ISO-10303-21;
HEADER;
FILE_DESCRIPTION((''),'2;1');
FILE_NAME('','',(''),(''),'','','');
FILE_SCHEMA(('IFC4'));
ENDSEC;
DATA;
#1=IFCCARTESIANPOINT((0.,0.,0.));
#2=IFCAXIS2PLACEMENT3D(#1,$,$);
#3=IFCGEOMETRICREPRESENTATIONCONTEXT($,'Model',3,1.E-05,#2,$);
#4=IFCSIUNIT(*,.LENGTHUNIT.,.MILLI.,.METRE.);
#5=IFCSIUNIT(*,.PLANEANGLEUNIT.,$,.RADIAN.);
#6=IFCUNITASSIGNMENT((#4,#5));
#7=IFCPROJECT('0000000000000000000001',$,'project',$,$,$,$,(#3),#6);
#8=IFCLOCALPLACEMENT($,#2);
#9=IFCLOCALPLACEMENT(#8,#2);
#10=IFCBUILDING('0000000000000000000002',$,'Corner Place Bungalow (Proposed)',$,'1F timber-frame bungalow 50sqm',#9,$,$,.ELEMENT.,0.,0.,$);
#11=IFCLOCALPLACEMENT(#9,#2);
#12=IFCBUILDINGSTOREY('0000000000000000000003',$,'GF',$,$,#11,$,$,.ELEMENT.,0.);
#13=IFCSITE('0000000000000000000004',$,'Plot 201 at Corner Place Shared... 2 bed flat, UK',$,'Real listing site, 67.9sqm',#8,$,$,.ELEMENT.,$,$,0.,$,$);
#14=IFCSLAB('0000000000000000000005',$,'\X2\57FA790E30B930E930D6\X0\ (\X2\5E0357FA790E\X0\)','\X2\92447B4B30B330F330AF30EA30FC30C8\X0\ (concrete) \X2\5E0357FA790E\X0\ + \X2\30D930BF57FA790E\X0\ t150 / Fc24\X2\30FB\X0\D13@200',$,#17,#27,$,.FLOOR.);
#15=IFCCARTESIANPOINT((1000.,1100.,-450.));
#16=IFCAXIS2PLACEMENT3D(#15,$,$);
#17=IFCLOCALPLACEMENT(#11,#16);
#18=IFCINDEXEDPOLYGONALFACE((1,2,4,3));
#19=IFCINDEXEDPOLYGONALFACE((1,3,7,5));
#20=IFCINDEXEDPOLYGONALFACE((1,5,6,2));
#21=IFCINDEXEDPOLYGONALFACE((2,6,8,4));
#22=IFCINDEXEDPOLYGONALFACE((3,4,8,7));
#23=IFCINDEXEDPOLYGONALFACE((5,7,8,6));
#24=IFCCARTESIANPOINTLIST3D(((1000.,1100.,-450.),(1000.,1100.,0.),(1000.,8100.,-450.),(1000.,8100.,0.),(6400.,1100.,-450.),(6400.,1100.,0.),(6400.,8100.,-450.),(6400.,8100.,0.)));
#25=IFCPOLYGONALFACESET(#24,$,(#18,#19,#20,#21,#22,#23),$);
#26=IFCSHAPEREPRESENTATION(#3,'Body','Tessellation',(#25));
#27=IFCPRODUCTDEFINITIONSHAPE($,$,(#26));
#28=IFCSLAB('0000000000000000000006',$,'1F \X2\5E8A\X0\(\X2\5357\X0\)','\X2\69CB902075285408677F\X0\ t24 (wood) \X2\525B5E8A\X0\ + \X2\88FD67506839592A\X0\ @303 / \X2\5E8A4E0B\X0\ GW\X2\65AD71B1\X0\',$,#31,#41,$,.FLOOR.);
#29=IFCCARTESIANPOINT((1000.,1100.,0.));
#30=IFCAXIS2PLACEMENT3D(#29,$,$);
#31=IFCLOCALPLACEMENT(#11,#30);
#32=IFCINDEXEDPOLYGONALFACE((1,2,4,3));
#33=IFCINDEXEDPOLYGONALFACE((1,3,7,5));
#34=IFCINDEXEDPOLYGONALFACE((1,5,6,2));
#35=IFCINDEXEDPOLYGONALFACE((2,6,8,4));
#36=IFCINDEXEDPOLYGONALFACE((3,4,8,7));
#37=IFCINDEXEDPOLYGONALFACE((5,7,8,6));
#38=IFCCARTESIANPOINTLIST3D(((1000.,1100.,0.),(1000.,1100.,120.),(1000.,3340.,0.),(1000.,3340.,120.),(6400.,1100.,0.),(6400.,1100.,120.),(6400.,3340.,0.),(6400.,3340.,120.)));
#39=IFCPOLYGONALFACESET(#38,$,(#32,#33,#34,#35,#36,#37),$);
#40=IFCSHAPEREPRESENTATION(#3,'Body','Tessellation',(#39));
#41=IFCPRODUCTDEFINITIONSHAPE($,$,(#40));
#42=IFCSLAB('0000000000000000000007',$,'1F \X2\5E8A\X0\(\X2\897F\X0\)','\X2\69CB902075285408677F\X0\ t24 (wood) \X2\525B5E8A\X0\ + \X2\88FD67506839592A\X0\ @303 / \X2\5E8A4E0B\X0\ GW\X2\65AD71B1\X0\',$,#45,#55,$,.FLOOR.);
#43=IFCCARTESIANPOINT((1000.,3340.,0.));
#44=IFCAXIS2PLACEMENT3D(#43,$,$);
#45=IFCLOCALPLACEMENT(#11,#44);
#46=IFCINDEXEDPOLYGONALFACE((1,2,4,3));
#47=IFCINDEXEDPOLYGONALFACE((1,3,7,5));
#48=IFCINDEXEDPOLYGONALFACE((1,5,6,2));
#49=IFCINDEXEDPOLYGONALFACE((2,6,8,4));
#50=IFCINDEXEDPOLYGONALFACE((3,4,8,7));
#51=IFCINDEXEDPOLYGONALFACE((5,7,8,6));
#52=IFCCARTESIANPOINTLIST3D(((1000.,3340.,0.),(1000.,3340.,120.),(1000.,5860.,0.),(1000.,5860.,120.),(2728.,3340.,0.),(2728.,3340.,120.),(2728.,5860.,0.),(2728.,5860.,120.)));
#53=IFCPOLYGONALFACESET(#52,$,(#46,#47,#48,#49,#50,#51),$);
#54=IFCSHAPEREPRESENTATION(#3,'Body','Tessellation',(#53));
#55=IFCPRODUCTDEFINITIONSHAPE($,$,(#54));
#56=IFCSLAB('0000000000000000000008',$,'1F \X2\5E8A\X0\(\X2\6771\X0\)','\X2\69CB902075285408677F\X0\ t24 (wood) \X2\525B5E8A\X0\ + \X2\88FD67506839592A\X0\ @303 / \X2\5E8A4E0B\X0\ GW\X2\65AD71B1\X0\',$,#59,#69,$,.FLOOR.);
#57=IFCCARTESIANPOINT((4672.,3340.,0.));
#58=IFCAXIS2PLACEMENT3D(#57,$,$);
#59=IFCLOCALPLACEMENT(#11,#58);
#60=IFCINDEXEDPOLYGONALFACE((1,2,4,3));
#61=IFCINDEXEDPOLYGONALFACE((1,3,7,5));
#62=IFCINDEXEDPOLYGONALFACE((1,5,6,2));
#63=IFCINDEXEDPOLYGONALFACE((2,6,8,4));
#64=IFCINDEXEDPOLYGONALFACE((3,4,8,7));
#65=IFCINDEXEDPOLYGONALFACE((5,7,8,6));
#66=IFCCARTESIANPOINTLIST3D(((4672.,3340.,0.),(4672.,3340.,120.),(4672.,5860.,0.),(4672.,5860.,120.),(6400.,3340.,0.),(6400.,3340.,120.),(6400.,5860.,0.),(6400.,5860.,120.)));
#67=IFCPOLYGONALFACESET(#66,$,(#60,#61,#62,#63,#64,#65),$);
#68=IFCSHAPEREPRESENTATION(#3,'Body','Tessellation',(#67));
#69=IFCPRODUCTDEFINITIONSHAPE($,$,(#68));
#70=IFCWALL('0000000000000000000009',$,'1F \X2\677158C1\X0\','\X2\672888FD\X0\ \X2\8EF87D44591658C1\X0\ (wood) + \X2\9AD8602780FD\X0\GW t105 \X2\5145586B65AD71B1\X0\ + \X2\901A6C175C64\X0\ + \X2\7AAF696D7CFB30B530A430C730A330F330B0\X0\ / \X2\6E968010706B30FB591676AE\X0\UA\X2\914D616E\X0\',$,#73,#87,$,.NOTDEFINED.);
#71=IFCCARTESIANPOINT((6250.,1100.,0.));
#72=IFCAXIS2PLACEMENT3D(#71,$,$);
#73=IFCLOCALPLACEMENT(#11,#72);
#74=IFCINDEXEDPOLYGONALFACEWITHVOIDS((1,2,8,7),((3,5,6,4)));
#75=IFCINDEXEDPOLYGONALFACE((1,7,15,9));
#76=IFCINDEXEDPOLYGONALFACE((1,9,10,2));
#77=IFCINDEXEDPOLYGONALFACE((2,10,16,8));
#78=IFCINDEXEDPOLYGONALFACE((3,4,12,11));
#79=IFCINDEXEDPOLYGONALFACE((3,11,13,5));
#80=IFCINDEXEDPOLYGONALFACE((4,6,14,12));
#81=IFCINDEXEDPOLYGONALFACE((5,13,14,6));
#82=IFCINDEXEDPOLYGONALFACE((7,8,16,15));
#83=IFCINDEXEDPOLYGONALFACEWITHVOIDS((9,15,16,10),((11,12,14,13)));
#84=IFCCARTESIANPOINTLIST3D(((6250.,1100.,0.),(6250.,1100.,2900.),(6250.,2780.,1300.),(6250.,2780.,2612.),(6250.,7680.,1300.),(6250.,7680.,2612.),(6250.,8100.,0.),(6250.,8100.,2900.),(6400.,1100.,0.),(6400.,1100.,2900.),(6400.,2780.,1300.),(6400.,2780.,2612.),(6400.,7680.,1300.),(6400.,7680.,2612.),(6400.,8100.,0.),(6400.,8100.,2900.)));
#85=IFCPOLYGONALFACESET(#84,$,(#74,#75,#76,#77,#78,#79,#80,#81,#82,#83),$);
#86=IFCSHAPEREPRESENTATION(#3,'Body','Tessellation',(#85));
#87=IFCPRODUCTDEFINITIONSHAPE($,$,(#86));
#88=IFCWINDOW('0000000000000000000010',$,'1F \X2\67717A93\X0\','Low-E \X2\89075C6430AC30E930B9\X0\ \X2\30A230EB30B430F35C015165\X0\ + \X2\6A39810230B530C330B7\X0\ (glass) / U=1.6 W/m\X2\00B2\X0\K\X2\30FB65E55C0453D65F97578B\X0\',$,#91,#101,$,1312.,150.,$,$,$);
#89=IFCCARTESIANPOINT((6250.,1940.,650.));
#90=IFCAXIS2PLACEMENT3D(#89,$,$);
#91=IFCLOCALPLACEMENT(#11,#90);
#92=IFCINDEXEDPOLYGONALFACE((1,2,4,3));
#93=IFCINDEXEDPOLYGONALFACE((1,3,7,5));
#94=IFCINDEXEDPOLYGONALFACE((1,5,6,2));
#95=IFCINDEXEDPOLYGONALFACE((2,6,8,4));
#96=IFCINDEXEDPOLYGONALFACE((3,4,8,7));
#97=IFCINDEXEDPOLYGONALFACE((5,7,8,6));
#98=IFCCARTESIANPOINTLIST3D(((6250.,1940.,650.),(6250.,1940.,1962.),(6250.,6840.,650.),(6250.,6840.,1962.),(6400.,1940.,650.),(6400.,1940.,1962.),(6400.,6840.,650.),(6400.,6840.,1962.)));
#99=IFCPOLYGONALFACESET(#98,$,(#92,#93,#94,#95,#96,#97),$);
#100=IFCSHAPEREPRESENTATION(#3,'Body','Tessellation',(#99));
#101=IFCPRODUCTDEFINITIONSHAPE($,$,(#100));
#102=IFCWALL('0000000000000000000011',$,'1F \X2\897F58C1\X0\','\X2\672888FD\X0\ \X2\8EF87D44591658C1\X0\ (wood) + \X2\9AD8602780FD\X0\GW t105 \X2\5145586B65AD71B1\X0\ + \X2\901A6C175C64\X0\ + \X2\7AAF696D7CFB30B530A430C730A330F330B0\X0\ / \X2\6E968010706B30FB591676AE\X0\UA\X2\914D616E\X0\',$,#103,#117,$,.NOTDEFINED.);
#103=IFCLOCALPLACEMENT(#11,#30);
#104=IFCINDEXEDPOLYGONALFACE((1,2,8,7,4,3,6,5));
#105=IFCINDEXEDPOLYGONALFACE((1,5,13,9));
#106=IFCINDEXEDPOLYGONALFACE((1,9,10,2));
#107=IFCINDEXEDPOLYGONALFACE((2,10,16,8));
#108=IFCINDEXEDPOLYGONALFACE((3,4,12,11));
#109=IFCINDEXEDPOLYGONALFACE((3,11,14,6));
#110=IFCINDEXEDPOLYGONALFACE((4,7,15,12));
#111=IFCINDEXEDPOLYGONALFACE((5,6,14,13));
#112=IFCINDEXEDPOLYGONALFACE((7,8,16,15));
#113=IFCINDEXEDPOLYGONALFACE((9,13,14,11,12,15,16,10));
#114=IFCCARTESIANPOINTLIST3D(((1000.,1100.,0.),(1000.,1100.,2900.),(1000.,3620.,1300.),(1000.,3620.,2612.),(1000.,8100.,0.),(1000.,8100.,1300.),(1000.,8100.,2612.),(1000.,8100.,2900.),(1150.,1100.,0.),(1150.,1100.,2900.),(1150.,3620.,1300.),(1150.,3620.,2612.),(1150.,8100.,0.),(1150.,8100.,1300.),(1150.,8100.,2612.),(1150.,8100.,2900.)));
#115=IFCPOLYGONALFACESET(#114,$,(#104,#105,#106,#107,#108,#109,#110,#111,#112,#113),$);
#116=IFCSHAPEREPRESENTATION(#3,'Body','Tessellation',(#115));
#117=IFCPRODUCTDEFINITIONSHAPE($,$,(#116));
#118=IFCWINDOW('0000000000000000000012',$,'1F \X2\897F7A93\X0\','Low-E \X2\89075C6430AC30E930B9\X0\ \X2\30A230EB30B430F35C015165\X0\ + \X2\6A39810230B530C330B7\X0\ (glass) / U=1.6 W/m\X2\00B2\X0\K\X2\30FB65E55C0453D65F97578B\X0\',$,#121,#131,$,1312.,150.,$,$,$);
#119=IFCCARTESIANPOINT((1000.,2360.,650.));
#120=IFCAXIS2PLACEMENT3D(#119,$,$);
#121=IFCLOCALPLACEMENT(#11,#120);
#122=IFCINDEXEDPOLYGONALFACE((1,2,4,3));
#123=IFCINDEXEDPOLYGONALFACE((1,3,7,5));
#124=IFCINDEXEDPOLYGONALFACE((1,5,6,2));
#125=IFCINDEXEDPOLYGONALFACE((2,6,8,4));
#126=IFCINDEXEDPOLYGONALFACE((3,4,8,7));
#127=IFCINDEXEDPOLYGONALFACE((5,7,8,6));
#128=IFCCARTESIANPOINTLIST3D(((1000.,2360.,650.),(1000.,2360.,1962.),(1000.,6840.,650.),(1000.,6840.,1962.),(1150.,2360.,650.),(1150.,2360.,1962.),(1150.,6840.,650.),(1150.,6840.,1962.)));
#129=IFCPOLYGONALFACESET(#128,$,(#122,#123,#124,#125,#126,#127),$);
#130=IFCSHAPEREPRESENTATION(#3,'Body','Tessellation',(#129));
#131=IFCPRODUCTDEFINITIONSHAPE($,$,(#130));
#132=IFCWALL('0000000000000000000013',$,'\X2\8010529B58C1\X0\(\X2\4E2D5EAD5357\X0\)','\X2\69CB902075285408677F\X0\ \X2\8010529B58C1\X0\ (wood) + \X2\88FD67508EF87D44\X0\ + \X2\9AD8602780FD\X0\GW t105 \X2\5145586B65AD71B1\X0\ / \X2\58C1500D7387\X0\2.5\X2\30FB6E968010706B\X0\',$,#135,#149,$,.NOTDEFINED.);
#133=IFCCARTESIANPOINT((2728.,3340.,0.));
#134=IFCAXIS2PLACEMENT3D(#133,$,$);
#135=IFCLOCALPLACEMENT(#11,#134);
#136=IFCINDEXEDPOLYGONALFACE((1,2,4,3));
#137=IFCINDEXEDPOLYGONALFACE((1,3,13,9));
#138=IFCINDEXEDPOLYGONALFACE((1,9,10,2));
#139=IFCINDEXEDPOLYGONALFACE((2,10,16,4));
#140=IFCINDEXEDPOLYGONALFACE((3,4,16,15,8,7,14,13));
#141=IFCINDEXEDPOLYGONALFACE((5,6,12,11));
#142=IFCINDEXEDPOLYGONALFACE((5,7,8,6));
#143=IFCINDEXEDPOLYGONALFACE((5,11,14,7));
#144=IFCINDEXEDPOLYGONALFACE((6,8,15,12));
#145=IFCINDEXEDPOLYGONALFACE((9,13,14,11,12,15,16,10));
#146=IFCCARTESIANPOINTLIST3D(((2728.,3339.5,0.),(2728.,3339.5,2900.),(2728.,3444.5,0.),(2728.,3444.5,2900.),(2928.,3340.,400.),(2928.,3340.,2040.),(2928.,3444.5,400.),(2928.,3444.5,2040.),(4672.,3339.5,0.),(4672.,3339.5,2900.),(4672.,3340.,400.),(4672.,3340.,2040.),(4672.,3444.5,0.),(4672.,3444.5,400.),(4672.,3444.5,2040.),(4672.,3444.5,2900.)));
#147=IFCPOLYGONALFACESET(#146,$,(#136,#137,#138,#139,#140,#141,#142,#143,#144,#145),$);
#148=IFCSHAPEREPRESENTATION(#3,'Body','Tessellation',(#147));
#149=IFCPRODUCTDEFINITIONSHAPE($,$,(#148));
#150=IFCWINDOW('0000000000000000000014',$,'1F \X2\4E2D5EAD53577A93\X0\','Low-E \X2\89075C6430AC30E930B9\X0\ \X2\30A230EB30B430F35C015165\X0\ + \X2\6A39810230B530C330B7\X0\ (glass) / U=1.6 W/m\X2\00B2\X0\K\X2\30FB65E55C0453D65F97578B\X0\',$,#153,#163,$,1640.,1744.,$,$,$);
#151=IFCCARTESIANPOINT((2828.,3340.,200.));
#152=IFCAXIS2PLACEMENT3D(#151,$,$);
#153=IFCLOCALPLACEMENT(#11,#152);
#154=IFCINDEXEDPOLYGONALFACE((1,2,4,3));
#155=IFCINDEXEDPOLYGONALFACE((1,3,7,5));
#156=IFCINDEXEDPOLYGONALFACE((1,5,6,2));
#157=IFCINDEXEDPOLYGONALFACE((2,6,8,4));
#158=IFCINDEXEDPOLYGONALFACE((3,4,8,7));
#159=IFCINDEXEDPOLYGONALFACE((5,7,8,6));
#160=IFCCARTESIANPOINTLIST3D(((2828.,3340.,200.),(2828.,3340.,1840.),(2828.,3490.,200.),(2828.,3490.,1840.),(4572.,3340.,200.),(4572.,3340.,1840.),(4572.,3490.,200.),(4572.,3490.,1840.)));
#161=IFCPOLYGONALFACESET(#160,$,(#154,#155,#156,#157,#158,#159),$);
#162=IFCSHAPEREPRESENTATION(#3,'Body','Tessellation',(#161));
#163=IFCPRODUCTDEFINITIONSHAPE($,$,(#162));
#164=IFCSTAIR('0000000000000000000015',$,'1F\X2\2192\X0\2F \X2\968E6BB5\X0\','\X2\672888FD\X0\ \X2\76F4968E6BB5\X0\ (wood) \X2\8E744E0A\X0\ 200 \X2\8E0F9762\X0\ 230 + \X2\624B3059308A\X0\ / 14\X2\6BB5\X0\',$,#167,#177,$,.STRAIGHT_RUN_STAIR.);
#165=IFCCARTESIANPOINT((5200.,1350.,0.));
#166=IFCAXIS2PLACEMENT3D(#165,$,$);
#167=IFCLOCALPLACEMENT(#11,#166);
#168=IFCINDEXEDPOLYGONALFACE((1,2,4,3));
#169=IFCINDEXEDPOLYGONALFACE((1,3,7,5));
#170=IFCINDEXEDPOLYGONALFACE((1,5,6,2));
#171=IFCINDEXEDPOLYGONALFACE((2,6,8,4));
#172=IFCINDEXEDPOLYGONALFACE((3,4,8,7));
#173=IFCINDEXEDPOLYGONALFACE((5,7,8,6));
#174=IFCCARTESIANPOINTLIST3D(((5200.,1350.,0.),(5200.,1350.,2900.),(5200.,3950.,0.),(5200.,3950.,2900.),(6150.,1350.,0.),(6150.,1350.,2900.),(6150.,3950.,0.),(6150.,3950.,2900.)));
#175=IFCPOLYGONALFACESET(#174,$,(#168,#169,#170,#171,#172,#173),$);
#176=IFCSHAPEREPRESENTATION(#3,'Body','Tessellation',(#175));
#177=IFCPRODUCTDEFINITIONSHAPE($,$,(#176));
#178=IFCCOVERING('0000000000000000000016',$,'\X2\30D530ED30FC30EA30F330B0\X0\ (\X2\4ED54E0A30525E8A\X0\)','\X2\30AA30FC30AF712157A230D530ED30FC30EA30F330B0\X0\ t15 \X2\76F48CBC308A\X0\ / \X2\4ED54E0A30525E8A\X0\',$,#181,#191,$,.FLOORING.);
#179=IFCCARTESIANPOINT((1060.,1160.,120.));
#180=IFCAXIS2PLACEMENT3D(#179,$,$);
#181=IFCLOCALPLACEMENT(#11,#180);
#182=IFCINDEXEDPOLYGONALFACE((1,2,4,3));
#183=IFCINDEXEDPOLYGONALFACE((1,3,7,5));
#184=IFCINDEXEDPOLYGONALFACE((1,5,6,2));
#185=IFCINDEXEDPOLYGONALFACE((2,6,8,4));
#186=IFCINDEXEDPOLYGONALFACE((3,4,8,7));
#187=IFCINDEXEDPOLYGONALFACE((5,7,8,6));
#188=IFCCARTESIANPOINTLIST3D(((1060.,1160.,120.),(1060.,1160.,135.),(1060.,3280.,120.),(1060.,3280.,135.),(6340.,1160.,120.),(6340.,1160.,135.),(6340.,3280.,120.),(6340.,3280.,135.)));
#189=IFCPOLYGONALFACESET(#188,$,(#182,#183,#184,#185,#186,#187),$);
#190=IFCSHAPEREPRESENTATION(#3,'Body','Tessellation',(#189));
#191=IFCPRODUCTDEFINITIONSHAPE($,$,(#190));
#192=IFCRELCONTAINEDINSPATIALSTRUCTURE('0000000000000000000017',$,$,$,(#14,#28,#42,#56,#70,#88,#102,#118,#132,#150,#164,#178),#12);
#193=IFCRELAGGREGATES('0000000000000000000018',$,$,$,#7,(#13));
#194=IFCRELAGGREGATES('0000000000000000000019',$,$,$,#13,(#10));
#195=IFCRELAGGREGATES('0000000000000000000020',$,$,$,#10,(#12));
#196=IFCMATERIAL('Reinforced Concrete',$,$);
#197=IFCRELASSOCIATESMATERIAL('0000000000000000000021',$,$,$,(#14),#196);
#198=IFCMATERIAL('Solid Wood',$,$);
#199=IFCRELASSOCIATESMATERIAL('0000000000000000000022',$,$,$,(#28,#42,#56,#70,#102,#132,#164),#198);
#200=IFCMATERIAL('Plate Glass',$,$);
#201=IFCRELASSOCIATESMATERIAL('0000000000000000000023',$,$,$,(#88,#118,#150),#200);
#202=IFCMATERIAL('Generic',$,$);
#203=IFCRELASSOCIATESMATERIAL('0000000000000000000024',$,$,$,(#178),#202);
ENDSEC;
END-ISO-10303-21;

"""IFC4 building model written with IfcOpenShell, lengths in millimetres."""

from ifc_helpers import new_model, si_unit, frame, frame_2d, origin, place, context, project, spatial, rectangle, extrude, material, element, fill, save


model = new_model("IFC4")

# Units and contexts
model_context = context("Model", 3, precision=1e-05, world=origin())
ifc_project = project(units=[si_unit("LENGTHUNIT", "METRE", prefix="MILLI"), si_unit("PLANEANGLEUNIT", "RADIAN")], contexts=[model_context])

# Site, building, storey
site_placement = place(None, origin())
site = spatial("IfcSite", under=ifc_project, at=site_placement, Name="Plot 201 at Corner Place Shared... 2 bed flat, UK", ObjectType="Real listing site, 67.9sqm", CompositionType="ELEMENT", RefElevation=0.0)
building_placement = place(site_placement, origin())
building = spatial("IfcBuilding", under=site, at=building_placement, Name="Corner Place Bungalow (Proposed)", ObjectType="1F timber-frame bungalow 50sqm", CompositionType="ELEMENT", ElevationOfRefHeight=0.0, ElevationOfTerrain=0.0)
storey_placement = place(building_placement, origin())
storey = spatial("IfcBuildingStorey", under=building, at=storey_placement, Name="GF", CompositionType="ELEMENT", Elevation=0.0)

# Slabs
ifc_material_1 = material(Name="Reinforced Concrete")
slab_1_placement = place(storey_placement, frame((1000.0, 1100.0, -450.0)))
element("IfcSlab", 1, at=slab_1_placement, inside=storey, material=ifc_material_1, Name="基礎スラブ (布基礎)", Description="鉄筋コンクリート (concrete) 布基礎 + ベタ基礎 t150 / Fc24・D13@200", PredefinedType="FLOOR", context=model_context, shape_type="SweptSolid", body=[
    extrude(rectangle(XDim=5400.0, YDim=7000.0, at=frame_2d((2700.0, 3500.0))), frame((1000.0, 1100.0, -450.0)), (0.0, 0.0, 1.0), 450.0),
])
ifc_material_2 = material(Name="Solid Wood")
slab_2_placement = place(storey_placement, frame((1000.0, 1100.0, 0.0)))
element("IfcSlab", 2, at=slab_2_placement, inside=storey, material=ifc_material_2, Name="1F 床(南)", Description="構造用合板 t24 (wood) 剛床 + 製材根太 @303 / 床下 GW断熱", PredefinedType="FLOOR", context=model_context, shape_type="SweptSolid", body=[
    extrude(rectangle(XDim=5400.0, YDim=2240.0, at=frame_2d((2700.0, 1120.0))), frame((1000.0, 1100.0, 0.0)), (0.0, 0.0, 1.0), 120.0),
])
slab_3_placement = place(storey_placement, frame((1000.0, 3340.0, 0.0)))
element("IfcSlab", 3, at=slab_3_placement, inside=storey, material=ifc_material_2, Name="1F 床(西)", Description="構造用合板 t24 (wood) 剛床 + 製材根太 @303 / 床下 GW断熱", PredefinedType="FLOOR", context=model_context, shape_type="SweptSolid", body=[
    extrude(rectangle(XDim=1728.0, YDim=2520.0, at=frame_2d((864.0, 1260.0))), frame((1000.0, 3340.0, 0.0)), (0.0, 0.0, 1.0), 120.0),
])
slab_4_placement = place(storey_placement, frame((4672.0, 3340.0, 0.0)))
element("IfcSlab", 4, at=slab_4_placement, inside=storey, material=ifc_material_2, Name="1F 床(東)", Description="構造用合板 t24 (wood) 剛床 + 製材根太 @303 / 床下 GW断熱", PredefinedType="FLOOR", context=model_context, shape_type="SweptSolid", body=[
    extrude(rectangle(XDim=1728.0, YDim=2520.0, at=frame_2d((864.0, 1260.0))), frame((4672.0, 3340.0, 0.0)), (0.0, 0.0, 1.0), 120.0),
])
ifc_material_3 = material(Name="Generic")

# Shared definitions
ifc_material_4 = material(Name="Plate Glass")

# Walls, openings, windows
wall_1_placement = place(storey_placement, frame((6250.0, 1100.0, 0.0)))
wall_1 = element("IfcWall", 5, at=wall_1_placement, inside=storey, material=ifc_material_2, Name="1F 東壁", Description="木製 軸組外壁 (wood) + 高性能GW t105 充填断熱 + 通気層 + 窯業系サイディング / 準耐火・外皮UA配慮", PredefinedType="NOTDEFINED", context=model_context, shape_type="SweptSolid", body=[
    extrude(rectangle(XDim=150.0, YDim=7000.0, at=frame_2d((75.0, 3500.0))), frame((6250.0, 1100.0, 0.0)), (0.0, 0.0, 1.0), 2900.0),
])
opening_1_placement = place(storey_placement, frame((6250.0, 1940.0, 650.0)))
opening_1 = element("IfcOpeningElement", 6, at=opening_1_placement, cuts=wall_1, PredefinedType="NOTDEFINED", context=model_context, shape_type="SweptSolid", body=[
    extrude(rectangle(XDim=150.0, YDim=4900.0, at=frame_2d((75.0, 2450.0))), frame((6250.0, 1940.0, 650.0)), (0.0, 0.0, 1.0), 1312.0),
])
window_1_placement = place(storey_placement, frame((6250.0, 1940.0, 650.0)))
window_1 = element("IfcWindow", 7, at=window_1_placement, inside=storey, material=ifc_material_4, Name="1F 東窓", Description="Low-E 複層ガラス アルゴン封入 + 樹脂サッシ (glass) / U=1.6 W/m²K・日射取得型", OverallHeight=1312.0, OverallWidth=150.0, context=model_context, shape_type="SweptSolid", body=[
    extrude(rectangle(XDim=150.0, YDim=4900.0, at=frame_2d((75.0, 2450.0))), frame((6250.0, 1940.0, 650.0)), (0.0, 0.0, 1.0), 1312.0),
])
fill(opening_1, window_1)
wall_2_placement = place(storey_placement, frame((1000.0, 1100.0, 0.0)))
wall_2 = element("IfcWall", 8, at=wall_2_placement, inside=storey, material=ifc_material_2, Name="1F 西壁", Description="木製 軸組外壁 (wood) + 高性能GW t105 充填断熱 + 通気層 + 窯業系サイディング / 準耐火・外皮UA配慮", PredefinedType="NOTDEFINED", context=model_context, shape_type="SweptSolid", body=[
    extrude(rectangle(XDim=150.0, YDim=7000.0, at=frame_2d((75.0, 3500.0))), frame((1000.0, 1100.0, 0.0)), (0.0, 0.0, 1.0), 2900.0),
])
opening_2_placement = place(storey_placement, frame((1000.0, 2360.0, 650.0)))
opening_2 = element("IfcOpeningElement", 9, at=opening_2_placement, cuts=wall_2, PredefinedType="NOTDEFINED", context=model_context, shape_type="SweptSolid", body=[
    extrude(rectangle(XDim=150.0, YDim=4480.0, at=frame_2d((75.0, 2240.0))), frame((1000.0, 2360.0, 650.0)), (0.0, 0.0, 1.0), 1312.0),
])
window_2_placement = place(storey_placement, frame((1000.0, 2360.0, 650.0)))
window_2 = element("IfcWindow", 10, at=window_2_placement, inside=storey, material=ifc_material_4, Name="1F 西窓", Description="Low-E 複層ガラス アルゴン封入 + 樹脂サッシ (glass) / U=1.6 W/m²K・日射取得型", OverallHeight=1312.0, OverallWidth=150.0, context=model_context, shape_type="SweptSolid", body=[
    extrude(rectangle(XDim=150.0, YDim=4480.0, at=frame_2d((75.0, 2240.0))), frame((1000.0, 2360.0, 650.0)), (0.0, 0.0, 1.0), 1312.0),
])
fill(opening_2, window_2)
wall_3_placement = place(storey_placement, frame((2728.0, 3340.0, 0.0)))
wall_3 = element("IfcWall", 11, at=wall_3_placement, inside=storey, material=ifc_material_2, Name="耐力壁(中庭南)", Description="構造用合板 耐力壁 (wood) + 製材軸組 + 高性能GW t105 充填断熱 / 壁倍率2.5・準耐火", PredefinedType="NOTDEFINED", context=model_context, shape_type="SweptSolid", body=[
    extrude(rectangle(XDim=1944.0, YDim=105.0, at=frame_2d((972.0, 52.0))), frame((2728.0, 3340.0, 0.0)), (0.0, 0.0, 1.0), 2900.0),
])
opening_3_placement = place(storey_placement, frame((2828.0, 3340.0, 200.0)))
opening_3 = element("IfcOpeningElement", 12, at=opening_3_placement, cuts=wall_3, PredefinedType="NOTDEFINED", context=model_context, shape_type="SweptSolid", body=[
    extrude(rectangle(XDim=1744.0, YDim=150.0, at=frame_2d((872.0, 75.0))), frame((2828.0, 3340.0, 200.0)), (0.0, 0.0, 1.0), 1640.0),
])
window_3_placement = place(storey_placement, frame((2828.0, 3340.0, 200.0)))
window_3 = element("IfcWindow", 13, at=window_3_placement, inside=storey, material=ifc_material_4, Name="1F 中庭南窓", Description="Low-E 複層ガラス アルゴン封入 + 樹脂サッシ (glass) / U=1.6 W/m²K・日射取得型", OverallHeight=1640.0, OverallWidth=1744.0, context=model_context, shape_type="SweptSolid", body=[
    extrude(rectangle(XDim=1744.0, YDim=150.0, at=frame_2d((872.0, 75.0))), frame((2828.0, 3340.0, 200.0)), (0.0, 0.0, 1.0), 1640.0),
])
fill(opening_3, window_3)

# Stair
stair_placement = place(storey_placement, frame((5200.0, 1350.0, 0.0)))
element("IfcStair", 14, at=stair_placement, inside=storey, material=ifc_material_2, Name="1F→2F 階段", Description="木製 直階段 (wood) 蹴上 200 踏面 230 + 手すり / 14段", PredefinedType="STRAIGHT_RUN_STAIR", context=model_context, shape_type="SweptSolid", body=[
    extrude(rectangle(XDim=950.0, YDim=2600.0, at=frame_2d((475.0, 1300.0))), frame((5200.0, 1350.0, 0.0)), (0.0, 0.0, 1.0), 2900.0),
])

# Covering
covering_placement = place(storey_placement, frame((1060.0, 1160.0, 120.0)))
element("IfcCovering", 15, at=covering_placement, inside=storey, material=ifc_material_3, Name="フローリング (仕上げ床)", Description="オーク無垢フローリング t15 直貼り / 仕上げ床", PredefinedType="FLOORING", context=model_context, shape_type="SweptSolid", body=[
    extrude(rectangle(XDim=5280.0, YDim=2120.0, at=frame_2d((2640.0, 1060.0))), frame((1060.0, 1160.0, 120.0)), (0.0, 0.0, 1.0), 15.0),
])

save(model, "model.ifc")
